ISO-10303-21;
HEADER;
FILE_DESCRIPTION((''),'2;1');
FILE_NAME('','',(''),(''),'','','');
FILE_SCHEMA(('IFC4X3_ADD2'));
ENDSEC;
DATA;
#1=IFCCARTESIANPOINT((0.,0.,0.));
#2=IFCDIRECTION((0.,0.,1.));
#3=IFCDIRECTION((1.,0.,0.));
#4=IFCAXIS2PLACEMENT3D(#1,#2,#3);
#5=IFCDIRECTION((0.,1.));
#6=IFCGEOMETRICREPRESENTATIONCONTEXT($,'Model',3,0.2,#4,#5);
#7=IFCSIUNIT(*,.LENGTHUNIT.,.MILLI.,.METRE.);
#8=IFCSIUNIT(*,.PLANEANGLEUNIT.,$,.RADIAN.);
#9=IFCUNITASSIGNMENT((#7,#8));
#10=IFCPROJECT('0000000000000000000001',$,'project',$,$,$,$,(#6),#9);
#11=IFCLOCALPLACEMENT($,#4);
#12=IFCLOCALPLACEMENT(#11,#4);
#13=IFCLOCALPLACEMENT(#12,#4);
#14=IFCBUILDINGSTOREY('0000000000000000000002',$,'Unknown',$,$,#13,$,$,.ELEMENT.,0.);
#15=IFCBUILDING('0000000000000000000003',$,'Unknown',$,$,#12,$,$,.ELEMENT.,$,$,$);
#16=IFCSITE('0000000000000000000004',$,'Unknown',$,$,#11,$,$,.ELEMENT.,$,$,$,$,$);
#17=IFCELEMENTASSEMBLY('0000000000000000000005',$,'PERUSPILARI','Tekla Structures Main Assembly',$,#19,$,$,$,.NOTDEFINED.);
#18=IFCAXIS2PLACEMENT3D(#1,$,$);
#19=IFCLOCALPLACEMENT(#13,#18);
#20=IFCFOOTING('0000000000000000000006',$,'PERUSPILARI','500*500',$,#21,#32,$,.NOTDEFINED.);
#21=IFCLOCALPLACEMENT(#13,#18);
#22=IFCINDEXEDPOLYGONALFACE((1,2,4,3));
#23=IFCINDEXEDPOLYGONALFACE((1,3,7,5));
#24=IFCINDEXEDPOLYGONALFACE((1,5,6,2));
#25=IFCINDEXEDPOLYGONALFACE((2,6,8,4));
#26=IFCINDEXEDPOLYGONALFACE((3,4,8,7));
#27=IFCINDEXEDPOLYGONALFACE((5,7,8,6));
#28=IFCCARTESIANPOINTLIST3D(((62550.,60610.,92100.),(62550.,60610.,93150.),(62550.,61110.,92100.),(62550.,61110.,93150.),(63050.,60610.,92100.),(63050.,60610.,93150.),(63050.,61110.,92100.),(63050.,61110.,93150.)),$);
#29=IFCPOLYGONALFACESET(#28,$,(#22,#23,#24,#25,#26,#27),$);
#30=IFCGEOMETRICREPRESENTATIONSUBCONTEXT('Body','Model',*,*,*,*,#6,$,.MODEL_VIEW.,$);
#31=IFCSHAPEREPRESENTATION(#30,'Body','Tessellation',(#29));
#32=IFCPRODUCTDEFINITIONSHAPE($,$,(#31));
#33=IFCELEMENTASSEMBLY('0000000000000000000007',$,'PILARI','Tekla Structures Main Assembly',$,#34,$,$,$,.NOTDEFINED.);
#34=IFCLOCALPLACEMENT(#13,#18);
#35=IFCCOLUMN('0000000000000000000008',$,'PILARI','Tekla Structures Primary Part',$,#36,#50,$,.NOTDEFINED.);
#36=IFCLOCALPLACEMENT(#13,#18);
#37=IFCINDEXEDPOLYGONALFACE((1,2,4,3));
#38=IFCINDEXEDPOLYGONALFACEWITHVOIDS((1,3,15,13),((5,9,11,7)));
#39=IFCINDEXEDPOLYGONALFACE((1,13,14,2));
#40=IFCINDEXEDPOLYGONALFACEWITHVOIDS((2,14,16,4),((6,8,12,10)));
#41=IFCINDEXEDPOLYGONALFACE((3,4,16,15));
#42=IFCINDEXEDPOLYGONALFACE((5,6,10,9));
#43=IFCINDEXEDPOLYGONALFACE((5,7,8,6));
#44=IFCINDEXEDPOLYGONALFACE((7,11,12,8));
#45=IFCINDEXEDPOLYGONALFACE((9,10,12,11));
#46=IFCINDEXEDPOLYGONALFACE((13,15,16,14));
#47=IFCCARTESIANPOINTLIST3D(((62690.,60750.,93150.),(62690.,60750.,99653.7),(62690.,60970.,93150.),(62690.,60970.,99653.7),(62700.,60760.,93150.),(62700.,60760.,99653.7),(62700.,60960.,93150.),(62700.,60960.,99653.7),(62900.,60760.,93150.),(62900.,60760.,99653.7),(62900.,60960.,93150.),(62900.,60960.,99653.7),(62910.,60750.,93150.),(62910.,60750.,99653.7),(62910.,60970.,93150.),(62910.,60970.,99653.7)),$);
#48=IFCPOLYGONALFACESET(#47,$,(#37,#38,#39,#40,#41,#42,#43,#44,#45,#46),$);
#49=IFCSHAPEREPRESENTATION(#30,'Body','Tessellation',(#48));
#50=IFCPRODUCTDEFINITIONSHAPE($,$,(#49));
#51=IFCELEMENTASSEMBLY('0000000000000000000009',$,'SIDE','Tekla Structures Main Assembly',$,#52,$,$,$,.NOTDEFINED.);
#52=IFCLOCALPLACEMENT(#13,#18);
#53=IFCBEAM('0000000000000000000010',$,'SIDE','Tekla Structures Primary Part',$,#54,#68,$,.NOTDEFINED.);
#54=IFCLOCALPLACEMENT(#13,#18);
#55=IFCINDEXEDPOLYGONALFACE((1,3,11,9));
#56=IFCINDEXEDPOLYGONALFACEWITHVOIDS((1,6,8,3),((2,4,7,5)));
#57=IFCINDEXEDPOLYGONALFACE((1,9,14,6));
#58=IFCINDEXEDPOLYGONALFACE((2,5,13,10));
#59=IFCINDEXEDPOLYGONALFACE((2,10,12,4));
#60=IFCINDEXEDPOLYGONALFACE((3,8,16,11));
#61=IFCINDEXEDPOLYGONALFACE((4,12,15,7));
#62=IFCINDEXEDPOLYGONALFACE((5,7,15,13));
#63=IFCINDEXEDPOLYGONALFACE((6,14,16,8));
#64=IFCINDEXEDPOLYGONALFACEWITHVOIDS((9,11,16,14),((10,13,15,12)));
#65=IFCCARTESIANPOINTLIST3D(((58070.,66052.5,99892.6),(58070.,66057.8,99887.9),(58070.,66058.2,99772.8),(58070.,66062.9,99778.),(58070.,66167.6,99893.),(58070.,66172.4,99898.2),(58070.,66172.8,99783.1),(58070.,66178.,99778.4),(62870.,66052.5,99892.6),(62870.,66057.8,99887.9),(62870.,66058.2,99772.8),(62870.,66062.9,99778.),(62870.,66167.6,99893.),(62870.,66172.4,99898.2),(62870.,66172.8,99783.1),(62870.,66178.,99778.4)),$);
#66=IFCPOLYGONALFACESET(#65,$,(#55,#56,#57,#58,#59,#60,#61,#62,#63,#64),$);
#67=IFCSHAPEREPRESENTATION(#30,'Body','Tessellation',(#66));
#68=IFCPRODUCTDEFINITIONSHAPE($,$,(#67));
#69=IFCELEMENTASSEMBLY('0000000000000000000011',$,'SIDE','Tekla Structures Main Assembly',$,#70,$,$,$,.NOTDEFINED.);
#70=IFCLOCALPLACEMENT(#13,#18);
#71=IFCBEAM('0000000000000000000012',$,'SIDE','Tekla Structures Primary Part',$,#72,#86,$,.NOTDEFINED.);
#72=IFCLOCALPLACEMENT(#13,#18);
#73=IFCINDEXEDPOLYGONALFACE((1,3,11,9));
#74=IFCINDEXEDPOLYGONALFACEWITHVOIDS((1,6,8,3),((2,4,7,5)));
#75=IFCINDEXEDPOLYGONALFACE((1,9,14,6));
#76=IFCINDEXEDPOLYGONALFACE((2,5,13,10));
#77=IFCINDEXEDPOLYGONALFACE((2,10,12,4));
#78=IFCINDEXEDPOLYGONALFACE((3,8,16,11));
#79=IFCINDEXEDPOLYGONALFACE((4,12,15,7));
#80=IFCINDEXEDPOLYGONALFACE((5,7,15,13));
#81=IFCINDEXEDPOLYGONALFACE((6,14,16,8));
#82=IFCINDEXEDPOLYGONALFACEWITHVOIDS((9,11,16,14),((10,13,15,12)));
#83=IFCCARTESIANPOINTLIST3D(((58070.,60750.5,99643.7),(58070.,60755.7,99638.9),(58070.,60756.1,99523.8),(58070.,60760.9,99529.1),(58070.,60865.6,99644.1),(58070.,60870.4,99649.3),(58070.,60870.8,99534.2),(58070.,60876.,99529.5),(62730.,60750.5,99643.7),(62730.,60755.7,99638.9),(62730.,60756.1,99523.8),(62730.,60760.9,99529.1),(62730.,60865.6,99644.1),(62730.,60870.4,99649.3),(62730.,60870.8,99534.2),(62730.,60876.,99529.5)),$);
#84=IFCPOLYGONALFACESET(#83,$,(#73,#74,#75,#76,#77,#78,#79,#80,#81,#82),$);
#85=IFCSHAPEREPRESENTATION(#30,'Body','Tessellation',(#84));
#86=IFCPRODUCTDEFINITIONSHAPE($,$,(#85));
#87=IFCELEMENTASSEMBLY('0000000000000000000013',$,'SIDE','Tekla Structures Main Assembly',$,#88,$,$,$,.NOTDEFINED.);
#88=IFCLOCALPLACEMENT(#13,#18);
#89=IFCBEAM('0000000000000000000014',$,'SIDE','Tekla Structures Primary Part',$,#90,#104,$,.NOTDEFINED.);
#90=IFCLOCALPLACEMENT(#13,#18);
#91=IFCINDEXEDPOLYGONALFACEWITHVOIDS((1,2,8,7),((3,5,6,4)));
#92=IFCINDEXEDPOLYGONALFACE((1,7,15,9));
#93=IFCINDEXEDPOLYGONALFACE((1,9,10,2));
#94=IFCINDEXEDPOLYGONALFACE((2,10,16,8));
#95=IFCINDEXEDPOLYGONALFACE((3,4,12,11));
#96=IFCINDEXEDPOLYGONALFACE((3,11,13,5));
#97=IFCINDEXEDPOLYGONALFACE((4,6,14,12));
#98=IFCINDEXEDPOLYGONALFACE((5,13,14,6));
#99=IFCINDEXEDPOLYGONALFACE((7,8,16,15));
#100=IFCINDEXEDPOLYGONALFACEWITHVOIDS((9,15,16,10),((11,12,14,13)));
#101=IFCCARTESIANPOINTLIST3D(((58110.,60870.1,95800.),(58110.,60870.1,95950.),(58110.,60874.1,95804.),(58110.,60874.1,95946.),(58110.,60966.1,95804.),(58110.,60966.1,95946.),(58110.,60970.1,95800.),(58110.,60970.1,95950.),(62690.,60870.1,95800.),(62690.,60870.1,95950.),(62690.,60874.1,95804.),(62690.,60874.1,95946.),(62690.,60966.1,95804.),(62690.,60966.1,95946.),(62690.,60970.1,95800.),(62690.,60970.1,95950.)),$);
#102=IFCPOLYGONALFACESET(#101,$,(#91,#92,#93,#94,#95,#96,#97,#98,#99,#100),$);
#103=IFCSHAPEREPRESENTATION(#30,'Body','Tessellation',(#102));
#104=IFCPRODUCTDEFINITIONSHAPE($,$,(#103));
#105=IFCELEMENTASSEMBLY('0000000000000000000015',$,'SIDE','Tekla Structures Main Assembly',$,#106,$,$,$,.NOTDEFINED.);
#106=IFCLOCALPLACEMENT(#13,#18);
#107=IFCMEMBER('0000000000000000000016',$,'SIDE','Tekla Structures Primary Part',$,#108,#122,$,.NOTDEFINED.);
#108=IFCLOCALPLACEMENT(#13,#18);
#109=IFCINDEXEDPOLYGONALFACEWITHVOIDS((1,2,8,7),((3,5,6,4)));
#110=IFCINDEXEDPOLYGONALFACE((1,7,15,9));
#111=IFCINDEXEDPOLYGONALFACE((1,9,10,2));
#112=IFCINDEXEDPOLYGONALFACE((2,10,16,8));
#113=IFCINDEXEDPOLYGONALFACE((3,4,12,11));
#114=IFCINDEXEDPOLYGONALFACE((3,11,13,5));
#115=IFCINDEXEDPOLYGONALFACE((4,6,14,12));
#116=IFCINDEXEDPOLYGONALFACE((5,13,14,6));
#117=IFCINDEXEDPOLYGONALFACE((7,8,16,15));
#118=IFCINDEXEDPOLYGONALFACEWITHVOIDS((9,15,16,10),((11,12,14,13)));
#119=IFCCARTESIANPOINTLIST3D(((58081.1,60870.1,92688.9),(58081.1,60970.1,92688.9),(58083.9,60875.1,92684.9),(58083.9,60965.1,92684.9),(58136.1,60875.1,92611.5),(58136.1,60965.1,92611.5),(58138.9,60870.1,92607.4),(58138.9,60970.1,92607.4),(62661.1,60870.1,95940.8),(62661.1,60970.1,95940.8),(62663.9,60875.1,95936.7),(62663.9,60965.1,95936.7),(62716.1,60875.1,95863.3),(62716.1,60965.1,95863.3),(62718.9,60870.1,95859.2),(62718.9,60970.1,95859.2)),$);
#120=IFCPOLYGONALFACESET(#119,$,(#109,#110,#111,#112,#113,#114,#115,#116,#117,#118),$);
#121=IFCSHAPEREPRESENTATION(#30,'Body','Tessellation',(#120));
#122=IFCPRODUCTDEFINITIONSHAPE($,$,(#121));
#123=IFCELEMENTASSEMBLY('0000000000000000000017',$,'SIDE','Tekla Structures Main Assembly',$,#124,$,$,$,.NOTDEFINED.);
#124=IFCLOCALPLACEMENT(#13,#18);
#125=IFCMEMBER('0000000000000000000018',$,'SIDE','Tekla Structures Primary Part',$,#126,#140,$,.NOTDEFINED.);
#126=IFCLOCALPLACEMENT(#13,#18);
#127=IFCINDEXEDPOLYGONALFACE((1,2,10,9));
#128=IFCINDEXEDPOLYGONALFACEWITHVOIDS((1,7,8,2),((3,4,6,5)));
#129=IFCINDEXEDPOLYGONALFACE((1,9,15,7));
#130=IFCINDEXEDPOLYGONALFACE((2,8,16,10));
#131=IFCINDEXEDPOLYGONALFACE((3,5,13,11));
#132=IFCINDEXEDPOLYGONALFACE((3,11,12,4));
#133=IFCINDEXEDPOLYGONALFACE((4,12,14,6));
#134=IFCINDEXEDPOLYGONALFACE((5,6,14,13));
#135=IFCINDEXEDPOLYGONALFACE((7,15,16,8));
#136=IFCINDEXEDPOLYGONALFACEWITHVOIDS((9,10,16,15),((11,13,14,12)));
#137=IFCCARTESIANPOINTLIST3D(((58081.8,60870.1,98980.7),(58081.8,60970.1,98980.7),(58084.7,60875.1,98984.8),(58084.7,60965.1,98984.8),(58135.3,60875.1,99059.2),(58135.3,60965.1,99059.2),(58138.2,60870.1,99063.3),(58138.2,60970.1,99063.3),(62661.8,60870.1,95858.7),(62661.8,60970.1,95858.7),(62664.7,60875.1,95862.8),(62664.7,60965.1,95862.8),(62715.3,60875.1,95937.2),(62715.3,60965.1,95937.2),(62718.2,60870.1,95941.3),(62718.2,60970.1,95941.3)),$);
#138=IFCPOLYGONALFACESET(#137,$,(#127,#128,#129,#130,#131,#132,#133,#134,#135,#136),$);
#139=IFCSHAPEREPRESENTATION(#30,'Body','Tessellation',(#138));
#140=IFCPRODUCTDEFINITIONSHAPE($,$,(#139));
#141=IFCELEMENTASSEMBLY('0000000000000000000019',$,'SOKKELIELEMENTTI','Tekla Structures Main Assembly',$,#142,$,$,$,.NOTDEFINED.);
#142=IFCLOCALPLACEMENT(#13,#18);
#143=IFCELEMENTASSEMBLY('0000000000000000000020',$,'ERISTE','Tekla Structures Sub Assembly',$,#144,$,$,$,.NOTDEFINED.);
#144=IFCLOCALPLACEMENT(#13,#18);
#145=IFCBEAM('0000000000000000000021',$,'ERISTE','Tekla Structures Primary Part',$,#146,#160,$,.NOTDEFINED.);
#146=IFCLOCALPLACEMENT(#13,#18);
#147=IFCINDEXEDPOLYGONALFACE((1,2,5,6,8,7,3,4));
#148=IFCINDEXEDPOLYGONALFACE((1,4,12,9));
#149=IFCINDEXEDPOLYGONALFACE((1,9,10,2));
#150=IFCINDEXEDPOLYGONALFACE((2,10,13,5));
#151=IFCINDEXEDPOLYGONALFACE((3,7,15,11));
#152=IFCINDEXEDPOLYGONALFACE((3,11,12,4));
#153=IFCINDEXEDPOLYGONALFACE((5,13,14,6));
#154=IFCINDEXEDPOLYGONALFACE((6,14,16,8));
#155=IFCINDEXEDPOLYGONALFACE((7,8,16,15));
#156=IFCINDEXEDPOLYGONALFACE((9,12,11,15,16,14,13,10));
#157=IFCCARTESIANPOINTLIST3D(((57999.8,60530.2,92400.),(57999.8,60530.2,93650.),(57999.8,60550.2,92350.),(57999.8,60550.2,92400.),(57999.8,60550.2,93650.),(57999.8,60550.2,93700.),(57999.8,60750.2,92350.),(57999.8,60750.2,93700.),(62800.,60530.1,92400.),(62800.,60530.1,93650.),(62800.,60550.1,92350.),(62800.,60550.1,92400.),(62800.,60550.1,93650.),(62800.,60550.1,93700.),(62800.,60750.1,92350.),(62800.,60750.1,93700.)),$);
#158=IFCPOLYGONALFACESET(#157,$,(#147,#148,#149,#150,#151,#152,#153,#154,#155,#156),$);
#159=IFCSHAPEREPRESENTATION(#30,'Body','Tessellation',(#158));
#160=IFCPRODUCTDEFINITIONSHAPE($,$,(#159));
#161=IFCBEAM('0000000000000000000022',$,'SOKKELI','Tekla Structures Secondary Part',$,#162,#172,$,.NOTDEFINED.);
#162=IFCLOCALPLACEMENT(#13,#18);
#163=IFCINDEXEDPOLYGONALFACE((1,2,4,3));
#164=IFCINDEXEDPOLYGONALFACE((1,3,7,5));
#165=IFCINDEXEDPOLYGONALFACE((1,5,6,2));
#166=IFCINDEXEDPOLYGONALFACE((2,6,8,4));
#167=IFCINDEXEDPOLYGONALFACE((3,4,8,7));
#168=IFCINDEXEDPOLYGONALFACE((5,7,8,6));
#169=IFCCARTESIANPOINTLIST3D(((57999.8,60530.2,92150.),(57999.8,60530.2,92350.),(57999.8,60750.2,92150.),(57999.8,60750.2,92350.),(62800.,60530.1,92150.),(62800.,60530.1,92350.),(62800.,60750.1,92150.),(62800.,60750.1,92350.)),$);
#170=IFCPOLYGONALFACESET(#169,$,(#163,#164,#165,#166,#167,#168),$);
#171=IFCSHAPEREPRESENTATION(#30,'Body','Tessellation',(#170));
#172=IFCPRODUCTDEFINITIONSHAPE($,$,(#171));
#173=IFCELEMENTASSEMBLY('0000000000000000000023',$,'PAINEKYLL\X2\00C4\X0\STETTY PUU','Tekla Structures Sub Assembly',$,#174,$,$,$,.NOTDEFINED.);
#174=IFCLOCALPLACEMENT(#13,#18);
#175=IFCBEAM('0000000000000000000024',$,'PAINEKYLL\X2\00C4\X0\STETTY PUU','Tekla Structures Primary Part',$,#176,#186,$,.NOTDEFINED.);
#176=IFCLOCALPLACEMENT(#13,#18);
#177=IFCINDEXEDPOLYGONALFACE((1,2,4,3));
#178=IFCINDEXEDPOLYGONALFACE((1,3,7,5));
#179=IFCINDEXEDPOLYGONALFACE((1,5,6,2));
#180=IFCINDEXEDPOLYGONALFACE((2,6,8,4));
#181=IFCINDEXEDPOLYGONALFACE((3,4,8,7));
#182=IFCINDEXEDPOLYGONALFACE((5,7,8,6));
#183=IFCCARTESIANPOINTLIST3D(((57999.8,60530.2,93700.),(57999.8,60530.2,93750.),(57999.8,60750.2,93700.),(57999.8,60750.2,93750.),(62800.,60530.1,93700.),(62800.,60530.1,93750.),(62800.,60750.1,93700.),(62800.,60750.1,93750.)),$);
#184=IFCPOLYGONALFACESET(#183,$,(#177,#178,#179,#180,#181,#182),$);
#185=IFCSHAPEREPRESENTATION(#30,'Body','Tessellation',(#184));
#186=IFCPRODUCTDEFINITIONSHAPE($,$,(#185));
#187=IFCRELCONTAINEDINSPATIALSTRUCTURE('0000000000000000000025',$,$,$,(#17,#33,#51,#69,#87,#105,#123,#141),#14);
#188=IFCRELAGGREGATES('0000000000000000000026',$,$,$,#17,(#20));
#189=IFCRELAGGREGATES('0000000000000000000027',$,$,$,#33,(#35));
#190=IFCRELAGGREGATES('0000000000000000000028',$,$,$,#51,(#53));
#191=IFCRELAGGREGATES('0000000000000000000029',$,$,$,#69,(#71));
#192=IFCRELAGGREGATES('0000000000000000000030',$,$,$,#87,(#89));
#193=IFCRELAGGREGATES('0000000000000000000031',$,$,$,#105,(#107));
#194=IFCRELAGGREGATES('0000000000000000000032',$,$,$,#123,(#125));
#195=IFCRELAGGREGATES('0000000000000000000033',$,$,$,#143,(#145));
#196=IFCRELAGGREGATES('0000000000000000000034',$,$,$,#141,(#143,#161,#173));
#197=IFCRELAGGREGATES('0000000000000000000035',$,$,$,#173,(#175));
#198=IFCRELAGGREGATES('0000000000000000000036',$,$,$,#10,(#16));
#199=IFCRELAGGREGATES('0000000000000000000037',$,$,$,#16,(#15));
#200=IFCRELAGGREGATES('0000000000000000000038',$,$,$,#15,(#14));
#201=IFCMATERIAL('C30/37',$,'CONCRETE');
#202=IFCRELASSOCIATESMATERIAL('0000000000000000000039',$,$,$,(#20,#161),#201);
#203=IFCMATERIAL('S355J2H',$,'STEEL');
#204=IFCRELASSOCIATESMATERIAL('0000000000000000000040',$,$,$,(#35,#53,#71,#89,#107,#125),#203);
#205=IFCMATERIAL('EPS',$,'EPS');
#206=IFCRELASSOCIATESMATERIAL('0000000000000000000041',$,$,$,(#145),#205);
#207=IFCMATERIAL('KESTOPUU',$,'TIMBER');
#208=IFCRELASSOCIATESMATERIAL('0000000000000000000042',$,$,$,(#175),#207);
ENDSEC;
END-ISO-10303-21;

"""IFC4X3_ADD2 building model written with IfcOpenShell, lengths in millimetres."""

from ifc_helpers import new_model, si_unit, direction, frame, origin_with_axes, place, context, subcontext, project, spatial, line, indexed_curve, outline, extrude, material, element, aggregate, save


model = new_model("IFC4X3_ADD2")

# Units and contexts
model_context = context("Model", 3, precision=0.2, world=origin_with_axes(), true_north=direction((0.0, 1.0)))
body_context = subcontext(model_context, "Body", "Model", "MODEL_VIEW")
ifc_project = project(units=[si_unit("LENGTHUNIT", "METRE", prefix="MILLI"), si_unit("PLANEANGLEUNIT", "RADIAN")], contexts=[model_context])

# Site, building, storey
site_placement = place(None, origin_with_axes())
site = spatial("IfcSite", under=ifc_project, at=site_placement, Name="Unknown", CompositionType="ELEMENT")
building_placement = place(site_placement, origin_with_axes())
building = spatial("IfcBuilding", under=site, at=building_placement, Name="Unknown", CompositionType="ELEMENT")
storey_placement = place(building_placement, origin_with_axes())
storey = spatial("IfcBuildingStorey", under=building, at=storey_placement, Name="Unknown", CompositionType="ELEMENT", Elevation=0.0)

# Element assembly, footing
assembly_1_placement = place(storey_placement, frame((62800.0, 60860.0, 92100.0), z_axis=(-1.0, 0.0, 0.0), x_axis=(0.0, 0.0, 1.0)))
assembly_1 = element("IfcElementAssembly", 1, at=assembly_1_placement, inside=storey, Name="PERUSPILARI", Description="Tekla Structures Main Assembly", PredefinedType="NOTDEFINED")
ifc_material_1 = material(Name="C30/37", Category="CONCRETE")
footing_placement = place(assembly_1_placement, origin_with_axes())
footing = element("IfcFooting", 2, at=footing_placement, material=ifc_material_1, Name="PERUSPILARI", Description="500*500", PredefinedType="NOTDEFINED", context=body_context, shape_type="SolidModel", body=[
    extrude(outline(indexed_curve([(-250.0, -250.0), (250.0, -250.0), (250.0, 250.0), (-250.0, 250.0)], segments=[line(1, 2, 3, 4, 1)])), frame((0.0, 0.0, 0.0), z_axis=(-1.0, 0.0, 0.0), x_axis=(0.0, 0.0, 1.0)), (0.0, 0.0, -1.0), 1050.0),
])
aggregate(assembly_1, [footing])

# Element assembly, column
assembly_2_placement = place(storey_placement, frame((62800.0, 60860.0, 93150.0), z_axis=(-1.0, 0.0, 0.0), x_axis=(0.0, -0.000003, 1.0)))
assembly_2 = element("IfcElementAssembly", 3, at=assembly_2_placement, inside=storey, Name="PILARI", Description="Tekla Structures Main Assembly", PredefinedType="NOTDEFINED")
ifc_material_2 = material(Name="S355J2H", Category="STEEL")
column_placement = place(assembly_2_placement, origin_with_axes())
column = element("IfcColumn", 4, at=column_placement, material=ifc_material_2, Name="PILARI", Description="Tekla Structures Primary Part", PredefinedType="NOTDEFINED", context=body_context, shape_type="SolidModel", body=[
    extrude(outline(indexed_curve([(-110.0, -110.0), (110.0, -110.0), (110.0, 110.0), (-110.0, 110.0)], segments=[line(1, 2, 3, 4, 1)]), holes=[indexed_curve([(-100.0, -100.0), (-100.0, 100.0), (100.0, 100.0), (100.0, -100.0)], segments=[line(1, 2, 3, 4, 1)])]), frame((0.0, 0.0, 0.0), z_axis=(-1.0, 0.0, 0.0), x_axis=(0.0, 0.0, 1.0)), (0.0, 0.0, -1.0), 6503.7),
])
aggregate(assembly_2, [column])

# Element assemblies, beams
assembly_3_placement = place(storey_placement, frame((62870.0, 66115.3, 99835.5), z_axis=(0.0, 0.9989, 0.046897), x_axis=(-1.0, 0.0, 0.0)))
assembly_3 = element("IfcElementAssembly", 5, at=assembly_3_placement, inside=storey, Name="SIDE", Description="Tekla Structures Main Assembly", PredefinedType="NOTDEFINED")
beam_1_placement = place(assembly_3_placement, origin_with_axes())
beam_1 = element("IfcBeam", 6, at=beam_1_placement, material=ifc_material_2, Name="SIDE", Description="Tekla Structures Primary Part", PredefinedType="NOTDEFINED", context=body_context, shape_type="SolidModel", body=[
    extrude(outline(indexed_curve([(-60.0, -60.0), (60.0, -60.0), (60.0, 60.0), (-60.0, 60.0)], segments=[line(1, 2, 3, 4, 1)]), holes=[indexed_curve([(-55.0, -55.0), (-55.0, 55.0), (55.0, 55.0), (55.0, -55.0)], segments=[line(1, 2, 3, 4, 1)])]), frame((0.0, 0.0, 0.0), z_axis=(-1.0, 0.0, 0.0), x_axis=(0.0, 0.0, 1.0)), (0.0, 0.0, -1.0), 4800.0),
])
aggregate(assembly_3, [beam_1])
assembly_4_placement = place(storey_placement, frame((62730.0, 60813.2, 99586.6), z_axis=(0.0, 0.9989, 0.046897), x_axis=(-1.0, 0.0, 0.0)))
assembly_4 = element("IfcElementAssembly", 7, at=assembly_4_placement, inside=storey, Name="SIDE", Description="Tekla Structures Main Assembly", PredefinedType="NOTDEFINED")
beam_2_placement = place(assembly_4_placement, origin_with_axes())
beam_2 = element("IfcBeam", 8, at=beam_2_placement, material=ifc_material_2, Name="SIDE", Description="Tekla Structures Primary Part", PredefinedType="NOTDEFINED", context=body_context, shape_type="SolidModel", body=[
    extrude(outline(indexed_curve([(-60.0, -60.0), (60.0, -60.0), (60.0, 60.0), (-60.0, 60.0)], segments=[line(1, 2, 3, 4, 1)]), holes=[indexed_curve([(-55.0, -55.0), (-55.0, 55.0), (55.0, 55.0), (55.0, -55.0)], segments=[line(1, 2, 3, 4, 1)])]), frame((0.0, 0.0, 0.0), z_axis=(-1.0, 0.0, 0.0), x_axis=(0.0, 0.0, 1.0)), (0.0, 0.0, -1.0), 4660.0),
])
aggregate(assembly_4, [beam_2])
assembly_5_placement = place(storey_placement, frame((62690.0, 60920.1, 95875.0), z_axis=(0.0, 1.0, 0.0), x_axis=(-1.0, 0.0, 0.0)))
assembly_5 = element("IfcElementAssembly", 9, at=assembly_5_placement, inside=storey, Name="SIDE", Description="Tekla Structures Main Assembly", PredefinedType="NOTDEFINED")
beam_3_placement = place(assembly_5_placement, origin_with_axes())
beam_3 = element("IfcBeam", 10, at=beam_3_placement, material=ifc_material_2, Name="SIDE", Description="Tekla Structures Primary Part", PredefinedType="NOTDEFINED", context=body_context, shape_type="SolidModel", body=[
    extrude(outline(indexed_curve([(-50.0, -75.0), (50.0, -75.0), (50.0, 75.0), (-50.0, 75.0)], segments=[line(1, 2, 3, 4, 1)]), holes=[indexed_curve([(-46.0, -71.0), (-46.0, 71.0), (46.0, 71.0), (46.0, -71.0)], segments=[line(1, 2, 3, 4, 1)])]), frame((0.0, 0.0, 0.0), z_axis=(-1.0, 0.0, 0.0), x_axis=(0.0, 0.0, 1.0)), (0.0, 0.0, -1.0), 4580.0),
])
aggregate(assembly_5, [beam_3])

# Element assemblies, members
assembly_6_placement = place(storey_placement, frame((62690.0, 60920.1, 95900.0), z_axis=(0.0, 1.0, 0.0), x_axis=(-0.81538, 0.0, -0.578927)))
assembly_6 = element("IfcElementAssembly", 11, at=assembly_6_placement, inside=storey, Name="SIDE", Description="Tekla Structures Main Assembly", PredefinedType="NOTDEFINED")
member_1_placement = place(assembly_6_placement, origin_with_axes())
member_1 = element("IfcMember", 12, at=member_1_placement, material=ifc_material_2, Name="SIDE", Description="Tekla Structures Primary Part", PredefinedType="NOTDEFINED", context=body_context, shape_type="SolidModel", body=[
    extrude(outline(indexed_curve([(-50.0, -50.0), (50.0, -50.0), (50.0, 50.0), (-50.0, 50.0)], segments=[line(1, 2, 3, 4, 1)]), holes=[indexed_curve([(-45.0, -45.0), (-45.0, 45.0), (45.0, 45.0), (45.0, -45.0)], segments=[line(1, 2, 3, 4, 1)])]), frame((0.0, 0.0, 0.0), z_axis=(-1.0, 0.0, 0.0), x_axis=(0.0, 0.0, 1.0)), (0.0, 0.0, -1.0), 5617.0),
])
aggregate(assembly_6, [member_1])
assembly_7_placement = place(storey_placement, frame((62690.0, 60920.1, 95900.0), z_axis=(0.0, 1.0, 0.0), x_axis=(-0.826289, 0.0, 0.563246)))
assembly_7 = element("IfcElementAssembly", 13, at=assembly_7_placement, inside=storey, Name="SIDE", Description="Tekla Structures Main Assembly", PredefinedType="NOTDEFINED")
member_2_placement = place(assembly_7_placement, origin_with_axes())
member_2 = element("IfcMember", 14, at=member_2_placement, material=ifc_material_2, Name="SIDE", Description="Tekla Structures Primary Part", PredefinedType="NOTDEFINED", context=body_context, shape_type="SolidModel", body=[
    extrude(outline(indexed_curve([(-50.0, -50.0), (50.0, -50.0), (50.0, 50.0), (-50.0, 50.0)], segments=[line(1, 2, 3, 4, 1)]), holes=[indexed_curve([(-45.0, -45.0), (-45.0, 45.0), (45.0, 45.0), (45.0, -45.0)], segments=[line(1, 2, 3, 4, 1)])]), frame((0.0, 0.0, 0.0), z_axis=(-1.0, 0.0, 0.0), x_axis=(0.0, 0.0, 1.0)), (0.0, 0.0, -1.0), 5542.9),
])
aggregate(assembly_7, [member_2])

# Element assemblies, beams, voiding features
assembly_8_placement = place(storey_placement, frame((62800.0, 60810.1, 92950.0), z_axis=(0.000027, 1.0, 0.0), x_axis=(-1.0, 0.000027, 0.0)))
assembly_8 = element("IfcElementAssembly", 15, at=assembly_8_placement, inside=storey, Name="SOKKELIELEMENTTI", Description="Tekla Structures Main Assembly", PredefinedType="NOTDEFINED")
assembly_9_placement = place(assembly_8_placement, frame((0.0, 75.0, -170.0), z_axis=(0.0, 0.0, 1.0), x_axis=(1.0, 0.0, 0.0)))
assembly_9 = element("IfcElementAssembly", 16, at=assembly_9_placement, Name="ERISTE", Description="Tekla Structures Sub Assembly", PredefinedType="NOTDEFINED")
ifc_material_3 = material(Name="EPS", Category="EPS")
beam_4_placement = place(assembly_9_placement, origin_with_axes())
beam_4 = element("IfcBeam", 17, at=beam_4_placement, material=ifc_material_3, Name="ERISTE", Description="Tekla Structures Primary Part", PredefinedType="NOTDEFINED", context=body_context, shape_type="SolidModel", body=[
    extrude(outline(indexed_curve([(-110.0, -675.0), (110.0, -675.0), (110.0, 675.0), (-110.0, 675.0)], segments=[line(1, 2, 3, 4, 1)])), frame((0.0, 0.0, 0.0), z_axis=(-1.0, 0.0, 0.0), x_axis=(0.0, 0.0, 1.0)), (0.0, 0.0, -1.0), 4800.1),
])
voiding_feature_1_placement = place(beam_4_placement, frame((-1.0, 650.0, -100.0), z_axis=(0.0, 0.0, 1.0), x_axis=(1.0, 0.0, 0.0)))
element("IfcVoidingFeature", 18, at=voiding_feature_1_placement, cuts=beam_4, PredefinedType="HOLE", context=body_context, shape_type="SolidModel", body=[
    extrude(outline(indexed_curve([(-10.0, -25.0), (10.0, -25.0), (10.0, 25.0), (-10.0, 25.0)], segments=[line(1, 2, 3, 4, 1)])), frame((0.0, 0.0, 0.0), z_axis=(-1.0, 0.0, 0.0), x_axis=(0.0, 0.0, 1.0)), (0.0, 0.0, -1.0), 4802.1),
])
voiding_feature_2_placement = place(beam_4_placement, frame((-1.0, -650.0, -100.0), z_axis=(0.0, 0.0, 1.0), x_axis=(1.0, 0.0, 0.0)))
element("IfcVoidingFeature", 19, at=voiding_feature_2_placement, cuts=beam_4, PredefinedType="HOLE", context=body_context, shape_type="SolidModel", body=[
    extrude(outline(indexed_curve([(-10.0, -25.0), (10.0, -25.0), (10.0, 25.0), (-10.0, 25.0)], segments=[line(1, 2, 3, 4, 1)])), frame((0.0, 0.0, 0.0), z_axis=(-1.0, 0.0, 0.0), x_axis=(0.0, 0.0, 1.0)), (0.0, 0.0, -1.0), 4802.1),
])
aggregate(assembly_9, [beam_4])
beam_5_placement = place(assembly_8_placement, frame((0.0, -700.0, -170.0), z_axis=(0.0, 0.0, 1.0), x_axis=(1.0, 0.0, 0.0)))
beam_5 = element("IfcBeam", 20, at=beam_5_placement, material=ifc_material_1, Name="SOKKELI", Description="Tekla Structures Secondary Part", PredefinedType="NOTDEFINED", context=body_context, shape_type="SolidModel", body=[
    extrude(outline(indexed_curve([(-110.0, -100.0), (110.0, -100.0), (110.0, 100.0), (-110.0, 100.0)], segments=[line(1, 2, 3, 4, 1)])), frame((0.0, 0.0, 0.0), z_axis=(-1.0, 0.0, 0.0), x_axis=(0.0, 0.0, 1.0)), (0.0, 0.0, -1.0), 4800.1),
])
assembly_10_placement = place(assembly_8_placement, frame((0.0, 775.0, -170.0), z_axis=(0.0, -1.0, 0.0), x_axis=(1.0, 0.0, 0.0)))
assembly_10 = element("IfcElementAssembly", 21, at=assembly_10_placement, Name="PAINEKYLLÄSTETTY PUU", Description="Tekla Structures Sub Assembly", PredefinedType="NOTDEFINED")
aggregate(assembly_8, [assembly_9, beam_5, assembly_10])
ifc_material_4 = material(Name="KESTOPUU", Category="TIMBER")
beam_6_placement = place(assembly_10_placement, origin_with_axes())
beam_6 = element("IfcBeam", 22, at=beam_6_placement, material=ifc_material_4, Name="PAINEKYLLÄSTETTY PUU", Description="Tekla Structures Primary Part", PredefinedType="NOTDEFINED", context=body_context, shape_type="SolidModel", body=[
    extrude(outline(indexed_curve([(-25.0, -110.0), (25.0, -110.0), (25.0, 110.0), (-25.0, 110.0)], segments=[line(1, 2, 3, 4, 1)])), frame((0.0, 0.0, 0.0), z_axis=(-1.0, 0.0, 0.0), x_axis=(0.0, 0.0, 1.0)), (0.0, 0.0, -1.0), 4800.1),
])
aggregate(assembly_10, [beam_6])

save(model, "model.ifc")
